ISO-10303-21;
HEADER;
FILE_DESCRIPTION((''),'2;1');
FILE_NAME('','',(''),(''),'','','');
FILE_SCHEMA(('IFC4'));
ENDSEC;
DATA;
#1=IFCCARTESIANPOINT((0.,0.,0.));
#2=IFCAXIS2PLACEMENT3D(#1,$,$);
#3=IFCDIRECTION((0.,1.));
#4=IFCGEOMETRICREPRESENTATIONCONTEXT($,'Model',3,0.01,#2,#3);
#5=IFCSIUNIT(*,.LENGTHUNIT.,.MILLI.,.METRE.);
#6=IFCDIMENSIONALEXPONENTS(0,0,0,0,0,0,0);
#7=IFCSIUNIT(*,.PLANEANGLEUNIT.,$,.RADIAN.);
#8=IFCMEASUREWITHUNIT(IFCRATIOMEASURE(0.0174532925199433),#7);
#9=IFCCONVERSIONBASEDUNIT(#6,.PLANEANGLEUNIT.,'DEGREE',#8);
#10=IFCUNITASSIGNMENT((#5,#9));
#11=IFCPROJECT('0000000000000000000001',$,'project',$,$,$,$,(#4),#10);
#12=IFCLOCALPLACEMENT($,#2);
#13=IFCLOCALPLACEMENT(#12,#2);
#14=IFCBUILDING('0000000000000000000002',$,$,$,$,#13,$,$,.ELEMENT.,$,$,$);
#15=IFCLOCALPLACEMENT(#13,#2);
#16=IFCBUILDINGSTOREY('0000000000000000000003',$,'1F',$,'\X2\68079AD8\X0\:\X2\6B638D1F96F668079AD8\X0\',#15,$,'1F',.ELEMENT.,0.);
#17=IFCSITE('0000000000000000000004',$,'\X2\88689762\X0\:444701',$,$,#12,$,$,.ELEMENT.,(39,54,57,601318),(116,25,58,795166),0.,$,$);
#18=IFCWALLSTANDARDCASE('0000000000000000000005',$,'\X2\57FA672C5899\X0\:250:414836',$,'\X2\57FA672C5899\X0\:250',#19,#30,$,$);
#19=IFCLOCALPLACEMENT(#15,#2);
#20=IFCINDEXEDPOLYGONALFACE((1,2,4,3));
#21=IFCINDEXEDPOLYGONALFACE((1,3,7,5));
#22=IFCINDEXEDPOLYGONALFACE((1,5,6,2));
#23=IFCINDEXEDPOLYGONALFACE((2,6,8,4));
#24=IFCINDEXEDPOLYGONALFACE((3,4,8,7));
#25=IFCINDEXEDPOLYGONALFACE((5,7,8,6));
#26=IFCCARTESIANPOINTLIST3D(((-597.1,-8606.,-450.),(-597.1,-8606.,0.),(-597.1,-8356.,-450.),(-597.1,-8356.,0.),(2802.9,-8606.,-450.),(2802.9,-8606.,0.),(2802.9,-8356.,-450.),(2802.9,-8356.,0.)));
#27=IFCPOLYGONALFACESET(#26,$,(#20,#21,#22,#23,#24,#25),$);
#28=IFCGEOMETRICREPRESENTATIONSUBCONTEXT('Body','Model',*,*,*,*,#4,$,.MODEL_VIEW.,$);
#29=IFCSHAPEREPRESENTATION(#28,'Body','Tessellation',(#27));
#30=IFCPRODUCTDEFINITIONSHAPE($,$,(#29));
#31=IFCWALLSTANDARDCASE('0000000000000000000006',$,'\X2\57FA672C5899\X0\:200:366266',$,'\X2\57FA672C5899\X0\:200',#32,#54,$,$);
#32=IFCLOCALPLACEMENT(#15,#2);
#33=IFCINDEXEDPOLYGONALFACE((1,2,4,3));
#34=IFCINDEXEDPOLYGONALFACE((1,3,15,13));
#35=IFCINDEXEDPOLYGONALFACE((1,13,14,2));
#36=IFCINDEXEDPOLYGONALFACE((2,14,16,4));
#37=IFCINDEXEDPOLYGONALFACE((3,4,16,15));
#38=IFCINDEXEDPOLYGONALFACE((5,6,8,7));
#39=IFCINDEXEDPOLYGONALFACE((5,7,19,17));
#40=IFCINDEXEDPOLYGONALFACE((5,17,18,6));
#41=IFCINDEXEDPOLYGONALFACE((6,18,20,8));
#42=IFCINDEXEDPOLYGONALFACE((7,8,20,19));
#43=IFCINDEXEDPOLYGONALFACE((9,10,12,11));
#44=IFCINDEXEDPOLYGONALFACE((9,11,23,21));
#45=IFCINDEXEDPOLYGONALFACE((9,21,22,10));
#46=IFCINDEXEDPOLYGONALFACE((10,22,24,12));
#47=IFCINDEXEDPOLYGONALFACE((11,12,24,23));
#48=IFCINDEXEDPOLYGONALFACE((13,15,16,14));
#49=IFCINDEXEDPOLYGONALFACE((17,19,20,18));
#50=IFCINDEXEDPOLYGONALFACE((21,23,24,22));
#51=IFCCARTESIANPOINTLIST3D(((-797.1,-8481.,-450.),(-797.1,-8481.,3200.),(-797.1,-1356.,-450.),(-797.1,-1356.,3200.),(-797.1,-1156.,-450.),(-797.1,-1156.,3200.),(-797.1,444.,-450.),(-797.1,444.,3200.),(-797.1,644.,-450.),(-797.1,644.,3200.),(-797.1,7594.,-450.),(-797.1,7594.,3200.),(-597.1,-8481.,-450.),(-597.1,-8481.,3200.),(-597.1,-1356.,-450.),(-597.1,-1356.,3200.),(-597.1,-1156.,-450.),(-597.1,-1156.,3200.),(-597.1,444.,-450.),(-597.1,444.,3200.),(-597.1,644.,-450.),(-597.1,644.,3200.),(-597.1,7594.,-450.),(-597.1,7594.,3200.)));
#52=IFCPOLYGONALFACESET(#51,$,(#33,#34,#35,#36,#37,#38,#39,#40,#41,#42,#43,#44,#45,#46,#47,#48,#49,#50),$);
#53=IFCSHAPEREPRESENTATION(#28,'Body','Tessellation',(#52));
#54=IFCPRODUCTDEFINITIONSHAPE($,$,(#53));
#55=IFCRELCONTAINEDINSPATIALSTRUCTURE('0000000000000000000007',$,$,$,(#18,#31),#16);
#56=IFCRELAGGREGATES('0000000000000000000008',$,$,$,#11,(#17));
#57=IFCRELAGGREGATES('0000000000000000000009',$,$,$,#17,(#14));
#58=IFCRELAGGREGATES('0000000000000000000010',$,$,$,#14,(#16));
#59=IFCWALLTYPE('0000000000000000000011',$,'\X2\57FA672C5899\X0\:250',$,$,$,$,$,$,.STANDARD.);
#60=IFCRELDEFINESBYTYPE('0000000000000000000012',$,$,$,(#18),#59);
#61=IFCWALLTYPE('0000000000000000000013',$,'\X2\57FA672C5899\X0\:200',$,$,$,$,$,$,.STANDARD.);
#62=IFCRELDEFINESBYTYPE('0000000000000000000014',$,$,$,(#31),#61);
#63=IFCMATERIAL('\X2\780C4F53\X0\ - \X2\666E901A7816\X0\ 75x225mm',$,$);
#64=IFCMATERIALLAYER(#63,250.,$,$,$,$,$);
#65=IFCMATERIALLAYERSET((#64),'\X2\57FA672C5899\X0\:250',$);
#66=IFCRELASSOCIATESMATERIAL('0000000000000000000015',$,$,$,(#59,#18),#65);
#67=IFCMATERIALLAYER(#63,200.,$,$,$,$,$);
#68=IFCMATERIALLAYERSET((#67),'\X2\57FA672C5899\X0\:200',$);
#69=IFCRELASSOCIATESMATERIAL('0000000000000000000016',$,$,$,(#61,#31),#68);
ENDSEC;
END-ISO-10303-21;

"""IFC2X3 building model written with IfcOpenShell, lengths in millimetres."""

from ifc_helpers import new_model, entity, si_unit, converted_unit, direction, frame, frame_2d, origin, place, context, subcontext, project, spatial, rectangle, extrude, material, layer, layer_set, layer_usage, type_object, element, save


model = new_model("IFC2X3")

# Units and contexts
model_context = context("Model", 3, precision=0.01, world=origin(), true_north=direction((0.0, 1.0)))
body_context = subcontext(model_context, "Body", "Model", "MODEL_VIEW")
ifc_project = project(units=[si_unit("LENGTHUNIT", "METRE", prefix="MILLI"), converted_unit("PLANEANGLEUNIT", "DEGREE", entity("IfcRatioMeasure", 0.0174532925199433), si_unit("PLANEANGLEUNIT", "RADIAN"), dimensions=[0, 0, 0, 0, 0, 0, 0])], contexts=[model_context])

# Site, building, storey
site_placement = place(None, origin())
site = spatial("IfcSite", under=ifc_project, at=site_placement, Name="表面:444701", CompositionType="ELEMENT", RefLatitude=(39, 54, 57, 601318), RefLongitude=(116, 25, 58, 795166), RefElevation=0.0)
building_placement = place(site_placement, origin())
building = spatial("IfcBuilding", under=site, at=building_placement, CompositionType="ELEMENT")
storey_placement = place(building_placement, origin())
storey = spatial("IfcBuildingStorey", under=building, at=storey_placement, Name="1F", ObjectType="标高:正负零标高", LongName="1F", CompositionType="ELEMENT", Elevation=0.0)

# Shared definitions
ifc_material_1 = material(Name="砌体 - 普通砖 75x225mm")
ifc_layer_1 = layer(ifc_material_1, 250.0)
ifc_layer_set_1 = layer_set([ifc_layer_1], Name="基本墙:250")
wall_type_1 = type_object("IfcWallType", Name="基本墙:250", PredefinedType="STANDARD", material=ifc_layer_set_1)

# Wall
ifc_layer_usage_1 = layer_usage(ifc_layer_set_1, "AXIS2", "NEGATIVE", 125.0)
wall_1_placement = place(storey_placement, frame((-597.1, -8481.0, -450.0)))
element("IfcWallStandardCase", 1, at=wall_1_placement, inside=storey, type_object=wall_type_1, material=ifc_layer_usage_1, Name="基本墙:250:414836", ObjectType="基本墙:250", context=body_context, shape_type="SweptSolid", body=[
    extrude(rectangle(XDim=3400.0, YDim=250.0, at=frame_2d((1700.0, 0.0), x_axis=(-1.0, 0.0))), origin(), (0.0, 0.0, 1.0), 450.0),
])

# Wall, openings
ifc_layer_2 = layer(ifc_material_1, 200.0)
ifc_layer_set_2 = layer_set([ifc_layer_2], Name="基本墙:200")
ifc_layer_usage_2 = layer_usage(ifc_layer_set_2, "AXIS2", "NEGATIVE", 100.0)
wall_type_2 = type_object("IfcWallType", Name="基本墙:200", PredefinedType="STANDARD", material=ifc_layer_set_2)
wall_2_placement = place(storey_placement, frame((-697.1, -8481.0, -450.0), z_axis=(0.0, 0.0, 1.0), x_axis=(0.0, 1.0, 0.0)))
wall_2 = element("IfcWallStandardCase", 2, at=wall_2_placement, inside=storey, type_object=wall_type_2, material=ifc_layer_usage_2, Name="基本墙:200:366266", ObjectType="基本墙:200", context=body_context, shape_type="SweptSolid", body=[
    extrude(rectangle(XDim=16075.0, YDim=200.0, at=frame_2d((8037.5, 0.0), x_axis=(-1.0, 0.0))), origin(), (0.0, 0.0, 1.0), 3650.0),
])
opening_1_placement = place(storey_placement, frame((-697.1, -8481.0, -450.0), z_axis=(0.0, 0.0, 1.0), x_axis=(0.0, 1.0, 0.0)))
element("IfcOpeningElement", 3, at=opening_1_placement, cuts=wall_2, ObjectType="Opening", context=body_context, shape_type="SweptSolid", body=[
    extrude(rectangle(XDim=3650.0, YDim=200.0, at=frame_2d((0.0, 0.0), x_axis=(1.0, 0.0))), frame((8925.0, 0.0, 1825.0), z_axis=(1.0, 0.0, 0.0), x_axis=(0.0, 0.0, -1.0)), (0.0, 0.0, 1.0), 200.0),
])
opening_2_placement = place(storey_placement, frame((-697.1, -8481.0, -450.0), z_axis=(0.0, 0.0, 1.0), x_axis=(0.0, 1.0, 0.0)))
element("IfcOpeningElement", 4, at=opening_2_placement, cuts=wall_2, ObjectType="Opening", context=body_context, shape_type="SweptSolid", body=[
    extrude(rectangle(XDim=3650.0, YDim=200.0, at=frame_2d((0.0, 0.0), x_axis=(1.0, 0.0))), frame((7125.0, 0.0, 1825.0), z_axis=(1.0, 0.0, 0.0), x_axis=(0.0, 0.0, -1.0)), (0.0, 0.0, 1.0), 200.0),
])

save(model, "model.ifc")
